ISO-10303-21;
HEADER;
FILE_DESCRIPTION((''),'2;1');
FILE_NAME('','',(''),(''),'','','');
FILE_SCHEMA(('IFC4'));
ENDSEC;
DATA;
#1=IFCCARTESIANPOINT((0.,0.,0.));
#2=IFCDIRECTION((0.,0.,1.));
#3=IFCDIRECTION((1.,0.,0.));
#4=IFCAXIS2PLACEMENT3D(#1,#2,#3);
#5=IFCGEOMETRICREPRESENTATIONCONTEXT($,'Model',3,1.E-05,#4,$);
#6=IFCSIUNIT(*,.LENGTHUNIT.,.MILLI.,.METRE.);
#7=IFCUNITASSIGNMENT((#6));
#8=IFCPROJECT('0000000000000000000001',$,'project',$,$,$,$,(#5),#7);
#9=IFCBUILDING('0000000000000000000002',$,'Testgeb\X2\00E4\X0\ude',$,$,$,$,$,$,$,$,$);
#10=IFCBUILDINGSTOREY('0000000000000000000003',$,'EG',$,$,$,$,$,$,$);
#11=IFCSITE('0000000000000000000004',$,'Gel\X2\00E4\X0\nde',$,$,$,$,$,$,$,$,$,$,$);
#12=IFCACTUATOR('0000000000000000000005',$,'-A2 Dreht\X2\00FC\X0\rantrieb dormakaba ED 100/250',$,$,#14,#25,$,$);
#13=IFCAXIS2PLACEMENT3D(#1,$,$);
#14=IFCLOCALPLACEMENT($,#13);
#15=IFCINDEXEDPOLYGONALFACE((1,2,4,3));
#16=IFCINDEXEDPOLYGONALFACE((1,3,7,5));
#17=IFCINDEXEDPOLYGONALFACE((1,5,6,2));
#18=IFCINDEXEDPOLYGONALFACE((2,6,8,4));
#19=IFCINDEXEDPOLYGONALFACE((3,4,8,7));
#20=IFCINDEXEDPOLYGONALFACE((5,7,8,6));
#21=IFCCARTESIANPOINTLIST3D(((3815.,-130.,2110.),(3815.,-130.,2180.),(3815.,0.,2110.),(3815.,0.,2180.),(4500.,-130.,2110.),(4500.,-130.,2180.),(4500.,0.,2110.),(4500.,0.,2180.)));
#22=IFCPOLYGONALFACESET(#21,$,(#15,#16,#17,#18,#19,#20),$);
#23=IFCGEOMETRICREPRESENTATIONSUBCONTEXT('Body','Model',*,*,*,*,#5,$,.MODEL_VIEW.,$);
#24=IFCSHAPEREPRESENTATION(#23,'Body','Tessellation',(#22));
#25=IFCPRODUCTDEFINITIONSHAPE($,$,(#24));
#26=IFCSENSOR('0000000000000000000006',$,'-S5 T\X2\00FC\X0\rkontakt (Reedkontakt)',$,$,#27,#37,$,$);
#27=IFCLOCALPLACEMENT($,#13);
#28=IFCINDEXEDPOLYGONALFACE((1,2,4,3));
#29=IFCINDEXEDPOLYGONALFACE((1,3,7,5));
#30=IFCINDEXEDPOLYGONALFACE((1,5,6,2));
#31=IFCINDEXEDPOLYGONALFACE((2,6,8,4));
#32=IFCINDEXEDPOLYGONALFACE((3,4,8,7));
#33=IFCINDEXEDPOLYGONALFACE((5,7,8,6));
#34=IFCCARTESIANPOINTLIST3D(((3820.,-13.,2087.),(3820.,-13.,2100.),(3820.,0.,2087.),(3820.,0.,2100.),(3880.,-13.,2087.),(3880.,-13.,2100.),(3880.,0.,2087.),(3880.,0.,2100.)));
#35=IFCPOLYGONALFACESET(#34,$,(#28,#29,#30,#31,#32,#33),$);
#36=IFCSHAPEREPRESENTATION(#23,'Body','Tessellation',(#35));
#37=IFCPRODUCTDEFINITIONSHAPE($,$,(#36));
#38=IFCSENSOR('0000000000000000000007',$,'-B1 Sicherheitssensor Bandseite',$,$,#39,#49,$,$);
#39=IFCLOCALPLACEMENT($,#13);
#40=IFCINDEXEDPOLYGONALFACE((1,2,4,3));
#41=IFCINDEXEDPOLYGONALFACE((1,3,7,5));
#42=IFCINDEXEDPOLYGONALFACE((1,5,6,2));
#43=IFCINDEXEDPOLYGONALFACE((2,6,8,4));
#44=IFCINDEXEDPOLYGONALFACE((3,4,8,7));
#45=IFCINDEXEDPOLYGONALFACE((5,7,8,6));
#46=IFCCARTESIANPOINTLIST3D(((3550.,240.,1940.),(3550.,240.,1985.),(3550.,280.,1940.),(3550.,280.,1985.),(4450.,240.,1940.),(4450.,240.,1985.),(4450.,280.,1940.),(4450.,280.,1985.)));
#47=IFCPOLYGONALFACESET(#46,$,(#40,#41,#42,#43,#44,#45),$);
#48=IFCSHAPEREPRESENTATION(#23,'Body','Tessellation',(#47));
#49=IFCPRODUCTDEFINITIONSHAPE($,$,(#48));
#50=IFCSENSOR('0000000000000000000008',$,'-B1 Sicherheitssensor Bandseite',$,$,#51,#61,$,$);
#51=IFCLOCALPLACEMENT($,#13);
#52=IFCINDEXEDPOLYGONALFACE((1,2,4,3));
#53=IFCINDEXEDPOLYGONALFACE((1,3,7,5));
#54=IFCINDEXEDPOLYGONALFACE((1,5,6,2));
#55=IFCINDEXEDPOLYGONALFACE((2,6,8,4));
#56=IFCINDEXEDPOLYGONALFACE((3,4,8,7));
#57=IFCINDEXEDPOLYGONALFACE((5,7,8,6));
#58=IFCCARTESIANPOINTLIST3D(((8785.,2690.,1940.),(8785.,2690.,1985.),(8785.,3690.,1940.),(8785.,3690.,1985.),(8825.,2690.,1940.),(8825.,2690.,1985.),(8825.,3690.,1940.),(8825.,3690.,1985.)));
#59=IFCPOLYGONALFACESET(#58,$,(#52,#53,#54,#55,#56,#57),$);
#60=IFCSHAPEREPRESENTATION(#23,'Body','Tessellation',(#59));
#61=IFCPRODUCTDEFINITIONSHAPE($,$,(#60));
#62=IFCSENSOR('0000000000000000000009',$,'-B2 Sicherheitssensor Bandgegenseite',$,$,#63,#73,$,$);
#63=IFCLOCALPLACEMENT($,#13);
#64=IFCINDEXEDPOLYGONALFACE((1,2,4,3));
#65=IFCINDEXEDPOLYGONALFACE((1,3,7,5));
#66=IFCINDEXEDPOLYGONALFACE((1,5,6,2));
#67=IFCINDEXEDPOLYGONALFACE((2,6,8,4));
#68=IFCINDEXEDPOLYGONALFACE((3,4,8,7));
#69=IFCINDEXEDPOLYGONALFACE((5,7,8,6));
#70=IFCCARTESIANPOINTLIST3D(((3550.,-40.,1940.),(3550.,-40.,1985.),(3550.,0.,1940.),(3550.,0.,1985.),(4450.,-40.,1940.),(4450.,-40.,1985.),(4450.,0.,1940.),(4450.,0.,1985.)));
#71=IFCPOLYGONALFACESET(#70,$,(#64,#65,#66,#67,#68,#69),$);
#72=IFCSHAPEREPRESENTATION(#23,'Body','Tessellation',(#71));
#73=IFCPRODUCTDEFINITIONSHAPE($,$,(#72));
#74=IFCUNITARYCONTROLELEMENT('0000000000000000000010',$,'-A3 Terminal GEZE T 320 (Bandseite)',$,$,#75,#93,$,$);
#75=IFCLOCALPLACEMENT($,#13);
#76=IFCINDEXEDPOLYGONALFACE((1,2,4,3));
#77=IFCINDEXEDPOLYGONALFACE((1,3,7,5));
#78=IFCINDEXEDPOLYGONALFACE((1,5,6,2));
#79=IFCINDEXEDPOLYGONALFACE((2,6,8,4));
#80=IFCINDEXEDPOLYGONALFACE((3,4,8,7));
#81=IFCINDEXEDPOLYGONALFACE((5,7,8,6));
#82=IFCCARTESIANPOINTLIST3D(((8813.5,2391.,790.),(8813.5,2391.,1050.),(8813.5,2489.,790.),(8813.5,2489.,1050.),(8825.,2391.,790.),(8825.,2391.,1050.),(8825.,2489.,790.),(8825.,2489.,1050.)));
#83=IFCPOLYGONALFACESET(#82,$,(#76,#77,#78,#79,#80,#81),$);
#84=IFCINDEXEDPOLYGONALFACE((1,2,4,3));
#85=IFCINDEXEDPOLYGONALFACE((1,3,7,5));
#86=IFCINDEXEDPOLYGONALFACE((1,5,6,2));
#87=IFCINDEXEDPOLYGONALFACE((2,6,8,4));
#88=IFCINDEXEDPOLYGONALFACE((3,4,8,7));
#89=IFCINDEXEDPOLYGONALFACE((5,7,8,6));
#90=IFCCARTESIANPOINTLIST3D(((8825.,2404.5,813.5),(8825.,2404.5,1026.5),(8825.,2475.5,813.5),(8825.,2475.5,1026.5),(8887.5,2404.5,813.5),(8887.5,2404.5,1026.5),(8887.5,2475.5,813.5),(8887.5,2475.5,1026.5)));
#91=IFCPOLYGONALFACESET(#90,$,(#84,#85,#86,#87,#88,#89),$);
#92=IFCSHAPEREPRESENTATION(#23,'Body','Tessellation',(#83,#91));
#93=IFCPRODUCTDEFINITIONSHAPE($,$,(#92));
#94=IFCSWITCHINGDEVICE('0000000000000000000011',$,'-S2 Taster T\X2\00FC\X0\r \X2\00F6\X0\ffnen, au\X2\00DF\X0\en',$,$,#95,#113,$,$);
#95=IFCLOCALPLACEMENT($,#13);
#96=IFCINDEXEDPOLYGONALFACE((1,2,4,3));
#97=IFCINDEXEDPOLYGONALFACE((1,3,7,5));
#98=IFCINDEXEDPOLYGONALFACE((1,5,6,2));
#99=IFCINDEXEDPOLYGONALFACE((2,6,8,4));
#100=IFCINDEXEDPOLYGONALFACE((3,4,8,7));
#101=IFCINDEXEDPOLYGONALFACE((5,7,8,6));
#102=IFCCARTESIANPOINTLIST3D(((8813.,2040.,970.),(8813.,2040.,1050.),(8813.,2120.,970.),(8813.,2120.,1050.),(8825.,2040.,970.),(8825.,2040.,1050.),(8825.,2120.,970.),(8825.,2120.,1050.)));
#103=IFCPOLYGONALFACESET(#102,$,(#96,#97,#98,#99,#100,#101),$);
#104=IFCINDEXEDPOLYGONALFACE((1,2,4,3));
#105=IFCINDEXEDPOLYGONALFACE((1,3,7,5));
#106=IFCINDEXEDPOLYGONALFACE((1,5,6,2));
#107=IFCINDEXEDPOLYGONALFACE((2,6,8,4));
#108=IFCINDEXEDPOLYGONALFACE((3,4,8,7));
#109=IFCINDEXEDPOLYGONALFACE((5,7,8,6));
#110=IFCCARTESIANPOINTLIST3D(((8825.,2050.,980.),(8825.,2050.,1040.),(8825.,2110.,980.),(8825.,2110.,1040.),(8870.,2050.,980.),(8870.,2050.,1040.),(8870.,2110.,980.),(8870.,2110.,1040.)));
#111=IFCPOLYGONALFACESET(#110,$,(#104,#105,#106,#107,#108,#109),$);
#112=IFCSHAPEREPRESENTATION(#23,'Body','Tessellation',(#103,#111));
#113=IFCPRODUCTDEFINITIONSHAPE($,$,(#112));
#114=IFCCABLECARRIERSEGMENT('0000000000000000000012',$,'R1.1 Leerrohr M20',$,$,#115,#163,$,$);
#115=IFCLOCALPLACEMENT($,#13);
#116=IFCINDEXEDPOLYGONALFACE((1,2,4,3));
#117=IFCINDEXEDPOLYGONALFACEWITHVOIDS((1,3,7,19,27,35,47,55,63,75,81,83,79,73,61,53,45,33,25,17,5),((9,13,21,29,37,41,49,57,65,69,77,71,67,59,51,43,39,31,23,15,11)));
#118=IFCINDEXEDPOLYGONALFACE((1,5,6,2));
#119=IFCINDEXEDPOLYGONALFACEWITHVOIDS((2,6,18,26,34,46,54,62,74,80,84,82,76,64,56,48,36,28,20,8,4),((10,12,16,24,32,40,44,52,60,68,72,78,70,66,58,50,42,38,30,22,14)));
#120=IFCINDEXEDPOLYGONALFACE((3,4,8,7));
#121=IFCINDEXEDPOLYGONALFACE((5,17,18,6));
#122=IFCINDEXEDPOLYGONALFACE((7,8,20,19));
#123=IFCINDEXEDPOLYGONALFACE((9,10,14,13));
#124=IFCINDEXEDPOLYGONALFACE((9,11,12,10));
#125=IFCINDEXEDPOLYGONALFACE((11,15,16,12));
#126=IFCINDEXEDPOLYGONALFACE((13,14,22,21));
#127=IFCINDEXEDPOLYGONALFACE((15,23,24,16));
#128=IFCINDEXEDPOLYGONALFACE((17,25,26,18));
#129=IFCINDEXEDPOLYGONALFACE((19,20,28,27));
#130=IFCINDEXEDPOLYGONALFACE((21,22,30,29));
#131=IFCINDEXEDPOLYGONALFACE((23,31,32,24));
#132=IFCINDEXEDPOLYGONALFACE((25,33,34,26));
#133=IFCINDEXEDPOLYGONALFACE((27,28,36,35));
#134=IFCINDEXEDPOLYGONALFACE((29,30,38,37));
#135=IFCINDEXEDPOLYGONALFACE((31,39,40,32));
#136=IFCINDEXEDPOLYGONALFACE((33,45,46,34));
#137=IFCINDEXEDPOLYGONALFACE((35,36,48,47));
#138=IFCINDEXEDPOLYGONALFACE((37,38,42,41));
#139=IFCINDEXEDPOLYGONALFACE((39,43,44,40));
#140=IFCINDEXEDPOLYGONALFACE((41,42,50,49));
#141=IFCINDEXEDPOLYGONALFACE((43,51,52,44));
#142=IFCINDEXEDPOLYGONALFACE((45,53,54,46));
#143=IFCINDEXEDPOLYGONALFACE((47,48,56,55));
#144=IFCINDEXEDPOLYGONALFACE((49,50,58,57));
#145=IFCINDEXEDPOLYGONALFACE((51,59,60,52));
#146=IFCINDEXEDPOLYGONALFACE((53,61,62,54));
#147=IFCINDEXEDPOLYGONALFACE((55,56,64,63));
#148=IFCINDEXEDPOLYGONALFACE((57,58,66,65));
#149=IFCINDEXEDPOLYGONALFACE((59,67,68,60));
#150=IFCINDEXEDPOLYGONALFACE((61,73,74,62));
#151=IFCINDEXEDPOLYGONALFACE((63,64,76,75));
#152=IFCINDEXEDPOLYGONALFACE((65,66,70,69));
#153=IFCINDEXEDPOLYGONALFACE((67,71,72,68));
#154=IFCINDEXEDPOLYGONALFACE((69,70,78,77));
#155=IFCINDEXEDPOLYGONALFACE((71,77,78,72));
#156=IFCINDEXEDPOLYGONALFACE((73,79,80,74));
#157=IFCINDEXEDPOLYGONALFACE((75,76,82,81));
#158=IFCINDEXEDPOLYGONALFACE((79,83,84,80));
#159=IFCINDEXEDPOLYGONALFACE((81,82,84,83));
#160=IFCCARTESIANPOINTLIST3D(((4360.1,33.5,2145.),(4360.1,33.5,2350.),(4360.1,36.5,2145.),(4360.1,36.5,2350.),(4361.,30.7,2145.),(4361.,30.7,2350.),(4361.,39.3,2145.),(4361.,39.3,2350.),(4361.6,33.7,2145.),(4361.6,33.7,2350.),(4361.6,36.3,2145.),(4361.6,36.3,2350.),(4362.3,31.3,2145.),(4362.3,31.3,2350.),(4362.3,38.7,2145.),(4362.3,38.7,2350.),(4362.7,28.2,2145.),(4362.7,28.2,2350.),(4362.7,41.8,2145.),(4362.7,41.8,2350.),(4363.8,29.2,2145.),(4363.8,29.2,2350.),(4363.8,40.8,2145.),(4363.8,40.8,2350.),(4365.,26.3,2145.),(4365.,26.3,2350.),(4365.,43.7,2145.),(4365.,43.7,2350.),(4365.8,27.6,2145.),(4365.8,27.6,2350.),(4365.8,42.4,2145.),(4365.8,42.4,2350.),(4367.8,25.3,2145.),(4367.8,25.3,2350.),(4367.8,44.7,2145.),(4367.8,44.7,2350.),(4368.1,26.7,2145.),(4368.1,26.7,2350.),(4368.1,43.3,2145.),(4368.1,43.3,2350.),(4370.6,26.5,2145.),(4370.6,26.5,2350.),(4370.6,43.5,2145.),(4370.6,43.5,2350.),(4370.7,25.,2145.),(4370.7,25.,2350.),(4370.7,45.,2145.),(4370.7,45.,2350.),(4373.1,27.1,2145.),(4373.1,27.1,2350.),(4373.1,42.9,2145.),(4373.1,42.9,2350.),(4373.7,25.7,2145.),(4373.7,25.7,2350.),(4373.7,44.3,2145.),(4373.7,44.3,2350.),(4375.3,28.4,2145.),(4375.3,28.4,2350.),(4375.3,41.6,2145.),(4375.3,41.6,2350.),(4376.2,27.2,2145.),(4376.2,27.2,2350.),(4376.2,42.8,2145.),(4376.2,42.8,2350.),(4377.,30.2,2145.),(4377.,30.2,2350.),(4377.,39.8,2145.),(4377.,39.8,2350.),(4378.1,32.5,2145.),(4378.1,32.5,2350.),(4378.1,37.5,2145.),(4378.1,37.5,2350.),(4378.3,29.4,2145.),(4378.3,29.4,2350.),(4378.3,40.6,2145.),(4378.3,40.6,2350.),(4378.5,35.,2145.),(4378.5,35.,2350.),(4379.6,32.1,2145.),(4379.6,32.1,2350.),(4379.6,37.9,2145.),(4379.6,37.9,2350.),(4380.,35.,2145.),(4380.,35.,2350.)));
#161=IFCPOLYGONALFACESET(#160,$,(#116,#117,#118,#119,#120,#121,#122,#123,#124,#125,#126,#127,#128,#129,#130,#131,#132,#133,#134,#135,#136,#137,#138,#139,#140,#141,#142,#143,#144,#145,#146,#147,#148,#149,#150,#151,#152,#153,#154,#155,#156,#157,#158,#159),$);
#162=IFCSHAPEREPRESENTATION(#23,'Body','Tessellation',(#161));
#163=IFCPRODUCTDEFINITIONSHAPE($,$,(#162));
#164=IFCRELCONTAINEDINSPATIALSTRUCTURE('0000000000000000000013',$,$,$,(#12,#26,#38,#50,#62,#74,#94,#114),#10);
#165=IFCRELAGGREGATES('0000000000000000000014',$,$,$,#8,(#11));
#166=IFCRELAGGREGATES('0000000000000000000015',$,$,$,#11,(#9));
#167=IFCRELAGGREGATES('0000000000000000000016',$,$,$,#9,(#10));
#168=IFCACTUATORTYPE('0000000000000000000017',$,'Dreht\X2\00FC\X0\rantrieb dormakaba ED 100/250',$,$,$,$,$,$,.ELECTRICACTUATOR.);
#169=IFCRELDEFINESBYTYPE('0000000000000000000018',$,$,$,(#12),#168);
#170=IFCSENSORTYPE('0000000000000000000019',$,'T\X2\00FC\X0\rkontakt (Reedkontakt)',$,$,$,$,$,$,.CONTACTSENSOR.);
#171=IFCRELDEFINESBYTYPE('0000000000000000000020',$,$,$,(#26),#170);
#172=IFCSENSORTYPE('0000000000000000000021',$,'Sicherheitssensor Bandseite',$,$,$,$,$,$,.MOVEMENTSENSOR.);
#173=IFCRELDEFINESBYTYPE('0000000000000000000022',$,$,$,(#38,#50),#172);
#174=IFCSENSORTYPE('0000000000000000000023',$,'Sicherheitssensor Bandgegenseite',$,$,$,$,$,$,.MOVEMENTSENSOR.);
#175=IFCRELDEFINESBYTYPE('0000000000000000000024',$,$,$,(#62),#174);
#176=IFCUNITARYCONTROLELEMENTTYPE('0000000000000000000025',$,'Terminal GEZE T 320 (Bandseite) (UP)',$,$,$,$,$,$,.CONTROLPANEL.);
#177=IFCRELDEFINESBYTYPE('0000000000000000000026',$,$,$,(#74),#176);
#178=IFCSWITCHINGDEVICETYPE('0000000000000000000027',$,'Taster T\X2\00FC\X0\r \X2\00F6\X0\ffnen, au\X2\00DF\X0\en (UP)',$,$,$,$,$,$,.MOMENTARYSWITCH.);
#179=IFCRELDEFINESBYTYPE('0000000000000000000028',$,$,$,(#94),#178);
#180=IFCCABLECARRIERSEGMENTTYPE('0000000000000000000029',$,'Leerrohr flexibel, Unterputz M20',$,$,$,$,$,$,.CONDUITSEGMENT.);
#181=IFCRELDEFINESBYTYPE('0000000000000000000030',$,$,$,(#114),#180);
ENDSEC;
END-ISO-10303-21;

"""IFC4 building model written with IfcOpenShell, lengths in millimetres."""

from ifc_helpers import new_model, si_unit, frame, frame_2d, origin_with_axes, place, context, subcontext, project, spatial, rectangle, hollow_circle, extrude, type_object, element, save


model = new_model("IFC4")

# Units and contexts
model_context = context("Model", 3, precision=1e-05, world=origin_with_axes())
body_context = subcontext(model_context, "Body", "Model", "MODEL_VIEW")
ifc_project = project(units=[si_unit("LENGTHUNIT", "METRE", prefix="MILLI")], contexts=[model_context])

# Site, building, storey
site = spatial("IfcSite", under=ifc_project, Name="Gelände")
building = spatial("IfcBuilding", under=site, Name="Testgebäude")
storey = spatial("IfcBuildingStorey", under=building, Name="EG")

# Actuator
actuator_type = type_object("IfcActuatorType", Name="Drehtürantrieb dormakaba ED 100/250", PredefinedType="ELECTRICACTUATOR")
actuator_placement = place(None, frame((3815.0, -130.0, 2110.0), z_axis=(0.0, 0.0, 1.0), x_axis=(1.0, 0.0, 0.0)))
element("IfcActuator", 1, at=actuator_placement, inside=storey, type_object=actuator_type, Name="-A2 Drehtürantrieb dormakaba ED 100/250", context=body_context, shape_type="SweptSolid", body=[
    extrude(rectangle(XDim=685.0, YDim=130.0, at=frame_2d((342.5, 65.0))), None, (0.0, 0.0, 1.0), 70.0),
])

# Sensors
sensor_type_1 = type_object("IfcSensorType", Name="Türkontakt (Reedkontakt)", PredefinedType="CONTACTSENSOR")
sensor_1_placement = place(None, frame((3820.0, -13.0, 2087.0), z_axis=(0.0, 0.0, 1.0), x_axis=(1.0, 0.0, 0.0)))
element("IfcSensor", 2, at=sensor_1_placement, inside=storey, type_object=sensor_type_1, Name="-S5 Türkontakt (Reedkontakt)", context=body_context, shape_type="SweptSolid", body=[
    extrude(rectangle(XDim=60.0, YDim=13.0, at=frame_2d((30.0, 6.5))), None, (0.0, 0.0, 1.0), 13.0),
])
sensor_type_2 = type_object("IfcSensorType", Name="Sicherheitssensor Bandseite", PredefinedType="MOVEMENTSENSOR")
sensor_2_placement = place(None, frame((3550.0, 240.0, 1940.0), z_axis=(0.0, 0.0, 1.0), x_axis=(1.0, 0.0, 0.0)))
element("IfcSensor", 3, at=sensor_2_placement, inside=storey, type_object=sensor_type_2, Name="-B1 Sicherheitssensor Bandseite", context=body_context, shape_type="SweptSolid", body=[
    extrude(rectangle(XDim=900.0, YDim=40.0, at=frame_2d((450.0, 20.0))), None, (0.0, 0.0, 1.0), 45.0),
])
sensor_3_placement = place(None, frame((8825.0, 2690.0, 1940.0), z_axis=(0.0, 0.0, 1.0), x_axis=(0.0, 1.0, 0.0)))
element("IfcSensor", 4, at=sensor_3_placement, inside=storey, type_object=sensor_type_2, Name="-B1 Sicherheitssensor Bandseite", context=body_context, shape_type="SweptSolid", body=[
    extrude(rectangle(XDim=1000.0, YDim=40.0, at=frame_2d((500.0, 20.0))), None, (0.0, 0.0, 1.0), 45.0),
])
sensor_type_3 = type_object("IfcSensorType", Name="Sicherheitssensor Bandgegenseite", PredefinedType="MOVEMENTSENSOR")
sensor_4_placement = place(None, frame((3550.0, -40.0, 1940.0), z_axis=(0.0, 0.0, 1.0), x_axis=(1.0, 0.0, 0.0)))
element("IfcSensor", 5, at=sensor_4_placement, inside=storey, type_object=sensor_type_3, Name="-B2 Sicherheitssensor Bandgegenseite", context=body_context, shape_type="SweptSolid", body=[
    extrude(rectangle(XDim=900.0, YDim=40.0, at=frame_2d((450.0, 20.0))), None, (0.0, 0.0, 1.0), 45.0),
])

# Unitary control element
unitary_control_element_type = type_object("IfcUnitaryControlElementType", Name="Terminal GEZE T 320 (Bandseite) (UP)", PredefinedType="CONTROLPANEL")
unitary_control_element_placement = place(None, frame((8825.0, 2391.0, 790.0), z_axis=(0.0, 0.0, 1.0), x_axis=(0.0, 1.0, 0.0)))
element("IfcUnitaryControlElement", 6, at=unitary_control_element_placement, inside=storey, type_object=unitary_control_element_type, Name="-A3 Terminal GEZE T 320 (Bandseite)", context=body_context, shape_type="SweptSolid", body=[
    extrude(rectangle(XDim=98.0, YDim=11.5, at=frame_2d((49.0, 5.8))), None, (0.0, 0.0, 1.0), 260.0),
    extrude(rectangle(XDim=71.0, YDim=62.5, at=frame_2d((35.5, 31.2))), frame((13.5, -62.5, 23.5), z_axis=(0.0, 0.0, 1.0), x_axis=(1.0, 0.0, 0.0)), (0.0, 0.0, 1.0), 213.0),
])

# Switching device
switching_device_type = type_object("IfcSwitchingDeviceType", Name="Taster Tür öffnen, außen (UP)", PredefinedType="MOMENTARYSWITCH")
switching_device_placement = place(None, frame((8825.0, 2040.0, 970.0), z_axis=(0.0, 0.0, 1.0), x_axis=(0.0, 1.0, 0.0)))
element("IfcSwitchingDevice", 7, at=switching_device_placement, inside=storey, type_object=switching_device_type, Name="-S2 Taster Tür öffnen, außen", context=body_context, shape_type="SweptSolid", body=[
    extrude(rectangle(XDim=80.0, YDim=12.0, at=frame_2d((40.0, 6.0))), None, (0.0, 0.0, 1.0), 80.0),
    extrude(rectangle(XDim=60.0, YDim=45.0, at=frame_2d((30.0, 22.5))), frame((10.0, -45.0, 10.0), z_axis=(0.0, 0.0, 1.0), x_axis=(1.0, 0.0, 0.0)), (0.0, 0.0, 1.0), 60.0),
])

# Cable carrier segment
cable_carrier_segment_type_1 = type_object("IfcCableCarrierSegmentType", Name="Leerrohr flexibel, Unterputz M20", PredefinedType="CONDUITSEGMENT")
cable_carrier_segment_1_placement = place(None, frame((4370.0, 35.0, 2145.0), z_axis=(0.0, 0.0, 1.0), x_axis=(1.0, 0.0, 0.0)))
element("IfcCableCarrierSegment", 8, at=cable_carrier_segment_1_placement, inside=storey, type_object=cable_carrier_segment_type_1, Name="R1.1 Leerrohr M20", context=body_context, shape_type="SweptSolid", body=[
    extrude(hollow_circle(Radius=10.0, WallThickness=1.5), None, (0.0, 0.0, 1.0), 205.0),
])

save(model, "model.ifc")
